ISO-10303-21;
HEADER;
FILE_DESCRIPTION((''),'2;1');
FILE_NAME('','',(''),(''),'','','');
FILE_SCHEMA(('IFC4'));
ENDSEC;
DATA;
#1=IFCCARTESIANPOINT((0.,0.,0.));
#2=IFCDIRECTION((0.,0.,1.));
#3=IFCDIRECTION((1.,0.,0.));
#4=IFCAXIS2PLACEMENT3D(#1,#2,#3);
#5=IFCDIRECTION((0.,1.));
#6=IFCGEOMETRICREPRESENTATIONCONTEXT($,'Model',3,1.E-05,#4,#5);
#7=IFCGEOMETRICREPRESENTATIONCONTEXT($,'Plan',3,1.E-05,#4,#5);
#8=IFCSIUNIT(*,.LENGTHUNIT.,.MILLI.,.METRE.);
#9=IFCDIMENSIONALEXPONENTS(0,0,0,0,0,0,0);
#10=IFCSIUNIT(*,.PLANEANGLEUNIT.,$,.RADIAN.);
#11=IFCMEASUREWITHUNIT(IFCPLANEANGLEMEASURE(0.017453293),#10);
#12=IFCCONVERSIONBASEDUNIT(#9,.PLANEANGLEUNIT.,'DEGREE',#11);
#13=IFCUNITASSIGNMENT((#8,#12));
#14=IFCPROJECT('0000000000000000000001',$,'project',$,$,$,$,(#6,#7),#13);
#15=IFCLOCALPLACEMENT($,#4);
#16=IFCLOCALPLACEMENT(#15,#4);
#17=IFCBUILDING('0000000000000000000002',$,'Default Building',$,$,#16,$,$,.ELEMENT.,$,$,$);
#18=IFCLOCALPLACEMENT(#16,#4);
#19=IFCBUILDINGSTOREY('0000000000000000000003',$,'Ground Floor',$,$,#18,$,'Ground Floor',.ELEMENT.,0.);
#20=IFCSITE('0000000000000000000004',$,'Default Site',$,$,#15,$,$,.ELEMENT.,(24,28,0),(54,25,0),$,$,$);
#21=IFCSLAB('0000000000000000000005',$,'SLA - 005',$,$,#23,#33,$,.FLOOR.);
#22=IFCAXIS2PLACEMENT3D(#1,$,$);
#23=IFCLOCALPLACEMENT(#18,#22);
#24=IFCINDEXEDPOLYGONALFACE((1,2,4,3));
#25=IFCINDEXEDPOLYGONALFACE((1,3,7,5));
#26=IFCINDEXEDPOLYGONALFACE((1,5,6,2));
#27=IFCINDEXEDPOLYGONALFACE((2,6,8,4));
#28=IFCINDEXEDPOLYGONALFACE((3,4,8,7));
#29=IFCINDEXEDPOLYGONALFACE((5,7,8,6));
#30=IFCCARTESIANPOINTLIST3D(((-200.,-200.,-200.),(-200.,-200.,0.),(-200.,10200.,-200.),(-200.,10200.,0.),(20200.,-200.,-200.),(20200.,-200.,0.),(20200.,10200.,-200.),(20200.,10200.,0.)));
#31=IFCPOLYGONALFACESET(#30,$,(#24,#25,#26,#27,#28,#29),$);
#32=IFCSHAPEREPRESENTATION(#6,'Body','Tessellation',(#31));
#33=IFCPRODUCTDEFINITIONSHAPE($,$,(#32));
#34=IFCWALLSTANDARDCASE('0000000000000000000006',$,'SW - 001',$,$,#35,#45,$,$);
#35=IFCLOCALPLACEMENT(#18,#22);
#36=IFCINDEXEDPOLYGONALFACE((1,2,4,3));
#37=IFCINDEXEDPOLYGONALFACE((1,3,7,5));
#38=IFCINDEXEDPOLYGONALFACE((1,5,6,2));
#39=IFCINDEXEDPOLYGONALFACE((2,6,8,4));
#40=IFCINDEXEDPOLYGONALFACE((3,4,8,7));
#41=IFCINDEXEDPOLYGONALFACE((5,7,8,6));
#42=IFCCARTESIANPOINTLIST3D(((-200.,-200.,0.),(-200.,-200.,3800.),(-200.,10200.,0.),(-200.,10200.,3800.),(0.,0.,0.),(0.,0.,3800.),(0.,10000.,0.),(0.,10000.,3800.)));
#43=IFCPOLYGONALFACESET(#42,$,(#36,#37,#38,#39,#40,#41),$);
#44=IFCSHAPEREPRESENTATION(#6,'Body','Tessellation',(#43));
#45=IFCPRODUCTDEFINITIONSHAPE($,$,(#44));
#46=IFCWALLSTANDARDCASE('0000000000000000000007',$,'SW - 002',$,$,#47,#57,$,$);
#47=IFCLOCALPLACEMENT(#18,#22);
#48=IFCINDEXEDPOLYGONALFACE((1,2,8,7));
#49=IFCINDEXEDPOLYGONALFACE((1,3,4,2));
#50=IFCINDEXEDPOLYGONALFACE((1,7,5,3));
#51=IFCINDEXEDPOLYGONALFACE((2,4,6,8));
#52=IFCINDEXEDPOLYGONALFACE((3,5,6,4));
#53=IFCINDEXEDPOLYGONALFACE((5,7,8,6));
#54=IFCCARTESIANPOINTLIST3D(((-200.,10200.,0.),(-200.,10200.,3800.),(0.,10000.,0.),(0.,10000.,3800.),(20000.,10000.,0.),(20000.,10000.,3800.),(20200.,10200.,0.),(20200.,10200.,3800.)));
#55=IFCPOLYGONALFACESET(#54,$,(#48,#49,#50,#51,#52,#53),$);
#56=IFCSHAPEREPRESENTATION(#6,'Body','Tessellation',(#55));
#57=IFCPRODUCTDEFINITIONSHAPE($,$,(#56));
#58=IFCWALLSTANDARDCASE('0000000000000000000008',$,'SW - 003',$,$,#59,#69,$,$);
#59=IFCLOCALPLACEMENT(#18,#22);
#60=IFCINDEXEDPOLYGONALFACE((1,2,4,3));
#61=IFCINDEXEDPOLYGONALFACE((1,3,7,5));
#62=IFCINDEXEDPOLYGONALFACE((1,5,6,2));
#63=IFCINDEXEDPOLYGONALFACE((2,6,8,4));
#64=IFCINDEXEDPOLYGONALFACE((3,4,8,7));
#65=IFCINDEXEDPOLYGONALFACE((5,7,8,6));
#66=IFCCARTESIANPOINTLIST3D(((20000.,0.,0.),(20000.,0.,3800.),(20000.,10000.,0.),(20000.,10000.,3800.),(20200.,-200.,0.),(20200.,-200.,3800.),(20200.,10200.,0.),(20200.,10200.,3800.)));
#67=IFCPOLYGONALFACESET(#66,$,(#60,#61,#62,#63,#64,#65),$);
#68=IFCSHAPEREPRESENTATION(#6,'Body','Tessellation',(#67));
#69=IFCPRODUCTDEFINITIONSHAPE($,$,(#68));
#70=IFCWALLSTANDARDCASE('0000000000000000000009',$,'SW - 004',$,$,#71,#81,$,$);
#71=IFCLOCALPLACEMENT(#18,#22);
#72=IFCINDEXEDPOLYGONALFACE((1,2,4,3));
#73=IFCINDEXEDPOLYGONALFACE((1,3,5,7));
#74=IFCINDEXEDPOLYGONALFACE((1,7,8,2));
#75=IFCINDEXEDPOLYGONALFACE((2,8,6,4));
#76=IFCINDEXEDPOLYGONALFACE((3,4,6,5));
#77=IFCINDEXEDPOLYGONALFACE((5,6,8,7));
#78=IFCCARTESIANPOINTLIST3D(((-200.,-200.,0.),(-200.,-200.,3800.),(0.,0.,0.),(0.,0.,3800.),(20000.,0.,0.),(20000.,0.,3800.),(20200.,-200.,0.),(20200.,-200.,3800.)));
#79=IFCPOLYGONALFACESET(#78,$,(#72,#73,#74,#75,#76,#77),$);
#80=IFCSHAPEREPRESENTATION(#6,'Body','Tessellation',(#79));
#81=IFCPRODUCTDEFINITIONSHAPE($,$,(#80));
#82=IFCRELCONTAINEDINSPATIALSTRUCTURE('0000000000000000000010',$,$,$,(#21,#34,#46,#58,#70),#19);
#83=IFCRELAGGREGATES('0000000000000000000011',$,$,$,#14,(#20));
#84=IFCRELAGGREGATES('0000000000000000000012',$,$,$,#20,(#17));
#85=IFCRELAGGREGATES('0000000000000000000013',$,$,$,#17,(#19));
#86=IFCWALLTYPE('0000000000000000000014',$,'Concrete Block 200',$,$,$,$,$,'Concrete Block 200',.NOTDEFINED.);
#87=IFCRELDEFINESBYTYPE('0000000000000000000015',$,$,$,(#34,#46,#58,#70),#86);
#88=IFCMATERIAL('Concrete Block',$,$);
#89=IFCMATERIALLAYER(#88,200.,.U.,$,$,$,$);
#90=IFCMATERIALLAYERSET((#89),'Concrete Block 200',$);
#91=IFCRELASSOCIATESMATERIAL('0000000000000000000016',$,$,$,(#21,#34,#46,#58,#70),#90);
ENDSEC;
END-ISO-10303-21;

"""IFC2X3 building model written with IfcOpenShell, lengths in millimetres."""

from ifc_helpers import new_model, entity, si_unit, converted_unit, direction, frame, origin_with_axes, place, context, project, spatial, polyline, outline, extrude, material, layer, layer_set, layer_usage, type_object, element, save


model = new_model("IFC2X3")

# Units and contexts
model_context = context("Model", 3, precision=1e-05, world=origin_with_axes(), true_north=direction((0.0, 1.0)))
plan_context = context("Plan", 3, precision=1e-05, world=origin_with_axes(), true_north=direction((0.0, 1.0)))
ifc_project = project(units=[si_unit("LENGTHUNIT", "METRE", prefix="MILLI"), converted_unit("PLANEANGLEUNIT", "DEGREE", entity("IfcPlaneAngleMeasure", 0.017453293), si_unit("PLANEANGLEUNIT", "RADIAN"), dimensions=[0, 0, 0, 0, 0, 0, 0])], contexts=[model_context, plan_context])

# Site, building, storey
site_placement = place(None, origin_with_axes())
site = spatial("IfcSite", under=ifc_project, at=site_placement, Name="Default Site", CompositionType="ELEMENT", RefLatitude=(24, 28, 0), RefLongitude=(54, 25, 0))
building_placement = place(site_placement, origin_with_axes())
building = spatial("IfcBuilding", under=site, at=building_placement, Name="Default Building", CompositionType="ELEMENT")
storey_placement = place(building_placement, origin_with_axes())
storey = spatial("IfcBuildingStorey", under=building, at=storey_placement, Name="Ground Floor", LongName="Ground Floor", CompositionType="ELEMENT", Elevation=0.0)

# Slab
ifc_material = material(Name="Concrete Block")
ifc_layer = layer(ifc_material, 200.0, ventilated="UNKNOWN")
ifc_layer_set = layer_set([ifc_layer], Name="Concrete Block 200")
ifc_layer_usage_1 = layer_usage(ifc_layer_set, "AXIS3", "NEGATIVE", 200.0)
slab_placement = place(storey_placement, frame((-200.0, 10200.0, -200.0), z_axis=(0.0, 0.0, 1.0), x_axis=(1.0, 0.0, 0.0)))
element("IfcSlab", 1, at=slab_placement, inside=storey, material=ifc_layer_usage_1, Name="SLA - 005", PredefinedType="FLOOR", context=model_context, shape_type="SweptSolid", body=[
    extrude(outline(polyline([(0.0, 0.0), (20400.0, 0.0), (20400.0, -10400.0), (0.0, -10400.0), (0.0, 0.0)])), origin_with_axes(), (0.0, 0.0, 1.0), 200.0),
])

# Walls
ifc_layer_usage_2 = layer_usage(ifc_layer_set, "AXIS2", "POSITIVE", 0.0)
wall_type = type_object("IfcWallType", Name="Concrete Block 200", ElementType="Concrete Block 200", PredefinedType="NOTDEFINED")
wall_1_placement = place(storey_placement, frame((0.0, 0.0, 0.0), z_axis=(0.0, 0.0, 1.0), x_axis=(0.0, 1.0, 0.0)))
element("IfcWallStandardCase", 2, at=wall_1_placement, inside=storey, type_object=wall_type, material=ifc_layer_usage_2, Name="SW - 001", context=model_context, shape_type="SweptSolid", body=[
    extrude(outline(polyline([(0.0, 0.0), (10000.0, 0.0), (10200.0, 200.0), (-200.0, 200.0), (0.0, 0.0)])), origin_with_axes(), (0.0, 0.0, 1.0), 3800.0),
])
ifc_layer_usage_3 = layer_usage(ifc_layer_set, "AXIS2", "POSITIVE", 0.0)
wall_2_placement = place(storey_placement, frame((0.0, 10000.0, 0.0), z_axis=(0.0, 0.0, 1.0), x_axis=(1.0, 0.0, 0.0)))
element("IfcWallStandardCase", 3, at=wall_2_placement, inside=storey, type_object=wall_type, material=ifc_layer_usage_3, Name="SW - 002", context=model_context, shape_type="SweptSolid", body=[
    extrude(outline(polyline([(0.0, 0.0), (20000.0, 0.0), (20200.0, 200.0), (-200.0, 200.0), (0.0, 0.0)])), origin_with_axes(), (0.0, 0.0, 1.0), 3800.0),
])
ifc_layer_usage_4 = layer_usage(ifc_layer_set, "AXIS2", "POSITIVE", 0.0)
wall_3_placement = place(storey_placement, frame((20000.0, 10000.0, 0.0), z_axis=(0.0, 0.0, 1.0), x_axis=(0.0, -1.0, 0.0)))
element("IfcWallStandardCase", 4, at=wall_3_placement, inside=storey, type_object=wall_type, material=ifc_layer_usage_4, Name="SW - 003", context=model_context, shape_type="SweptSolid", body=[
    extrude(outline(polyline([(0.0, 0.0), (10000.0, 0.0), (10200.0, 200.0), (-200.0, 200.0), (0.0, 0.0)])), origin_with_axes(), (0.0, 0.0, 1.0), 3800.0),
])
ifc_layer_usage_5 = layer_usage(ifc_layer_set, "AXIS2", "POSITIVE", 0.0)
wall_4_placement = place(storey_placement, frame((20000.0, 0.0, 0.0), z_axis=(0.0, 0.0, 1.0), x_axis=(-1.0, 0.0, 0.0)))
element("IfcWallStandardCase", 5, at=wall_4_placement, inside=storey, type_object=wall_type, material=ifc_layer_usage_5, Name="SW - 004", context=model_context, shape_type="SweptSolid", body=[
    extrude(outline(polyline([(0.0, 0.0), (20000.0, 0.0), (20200.0, 200.0), (-200.0, 200.0), (0.0, 0.0)])), origin_with_axes(), (0.0, 0.0, 1.0), 3800.0),
])

save(model, "model.ifc")
